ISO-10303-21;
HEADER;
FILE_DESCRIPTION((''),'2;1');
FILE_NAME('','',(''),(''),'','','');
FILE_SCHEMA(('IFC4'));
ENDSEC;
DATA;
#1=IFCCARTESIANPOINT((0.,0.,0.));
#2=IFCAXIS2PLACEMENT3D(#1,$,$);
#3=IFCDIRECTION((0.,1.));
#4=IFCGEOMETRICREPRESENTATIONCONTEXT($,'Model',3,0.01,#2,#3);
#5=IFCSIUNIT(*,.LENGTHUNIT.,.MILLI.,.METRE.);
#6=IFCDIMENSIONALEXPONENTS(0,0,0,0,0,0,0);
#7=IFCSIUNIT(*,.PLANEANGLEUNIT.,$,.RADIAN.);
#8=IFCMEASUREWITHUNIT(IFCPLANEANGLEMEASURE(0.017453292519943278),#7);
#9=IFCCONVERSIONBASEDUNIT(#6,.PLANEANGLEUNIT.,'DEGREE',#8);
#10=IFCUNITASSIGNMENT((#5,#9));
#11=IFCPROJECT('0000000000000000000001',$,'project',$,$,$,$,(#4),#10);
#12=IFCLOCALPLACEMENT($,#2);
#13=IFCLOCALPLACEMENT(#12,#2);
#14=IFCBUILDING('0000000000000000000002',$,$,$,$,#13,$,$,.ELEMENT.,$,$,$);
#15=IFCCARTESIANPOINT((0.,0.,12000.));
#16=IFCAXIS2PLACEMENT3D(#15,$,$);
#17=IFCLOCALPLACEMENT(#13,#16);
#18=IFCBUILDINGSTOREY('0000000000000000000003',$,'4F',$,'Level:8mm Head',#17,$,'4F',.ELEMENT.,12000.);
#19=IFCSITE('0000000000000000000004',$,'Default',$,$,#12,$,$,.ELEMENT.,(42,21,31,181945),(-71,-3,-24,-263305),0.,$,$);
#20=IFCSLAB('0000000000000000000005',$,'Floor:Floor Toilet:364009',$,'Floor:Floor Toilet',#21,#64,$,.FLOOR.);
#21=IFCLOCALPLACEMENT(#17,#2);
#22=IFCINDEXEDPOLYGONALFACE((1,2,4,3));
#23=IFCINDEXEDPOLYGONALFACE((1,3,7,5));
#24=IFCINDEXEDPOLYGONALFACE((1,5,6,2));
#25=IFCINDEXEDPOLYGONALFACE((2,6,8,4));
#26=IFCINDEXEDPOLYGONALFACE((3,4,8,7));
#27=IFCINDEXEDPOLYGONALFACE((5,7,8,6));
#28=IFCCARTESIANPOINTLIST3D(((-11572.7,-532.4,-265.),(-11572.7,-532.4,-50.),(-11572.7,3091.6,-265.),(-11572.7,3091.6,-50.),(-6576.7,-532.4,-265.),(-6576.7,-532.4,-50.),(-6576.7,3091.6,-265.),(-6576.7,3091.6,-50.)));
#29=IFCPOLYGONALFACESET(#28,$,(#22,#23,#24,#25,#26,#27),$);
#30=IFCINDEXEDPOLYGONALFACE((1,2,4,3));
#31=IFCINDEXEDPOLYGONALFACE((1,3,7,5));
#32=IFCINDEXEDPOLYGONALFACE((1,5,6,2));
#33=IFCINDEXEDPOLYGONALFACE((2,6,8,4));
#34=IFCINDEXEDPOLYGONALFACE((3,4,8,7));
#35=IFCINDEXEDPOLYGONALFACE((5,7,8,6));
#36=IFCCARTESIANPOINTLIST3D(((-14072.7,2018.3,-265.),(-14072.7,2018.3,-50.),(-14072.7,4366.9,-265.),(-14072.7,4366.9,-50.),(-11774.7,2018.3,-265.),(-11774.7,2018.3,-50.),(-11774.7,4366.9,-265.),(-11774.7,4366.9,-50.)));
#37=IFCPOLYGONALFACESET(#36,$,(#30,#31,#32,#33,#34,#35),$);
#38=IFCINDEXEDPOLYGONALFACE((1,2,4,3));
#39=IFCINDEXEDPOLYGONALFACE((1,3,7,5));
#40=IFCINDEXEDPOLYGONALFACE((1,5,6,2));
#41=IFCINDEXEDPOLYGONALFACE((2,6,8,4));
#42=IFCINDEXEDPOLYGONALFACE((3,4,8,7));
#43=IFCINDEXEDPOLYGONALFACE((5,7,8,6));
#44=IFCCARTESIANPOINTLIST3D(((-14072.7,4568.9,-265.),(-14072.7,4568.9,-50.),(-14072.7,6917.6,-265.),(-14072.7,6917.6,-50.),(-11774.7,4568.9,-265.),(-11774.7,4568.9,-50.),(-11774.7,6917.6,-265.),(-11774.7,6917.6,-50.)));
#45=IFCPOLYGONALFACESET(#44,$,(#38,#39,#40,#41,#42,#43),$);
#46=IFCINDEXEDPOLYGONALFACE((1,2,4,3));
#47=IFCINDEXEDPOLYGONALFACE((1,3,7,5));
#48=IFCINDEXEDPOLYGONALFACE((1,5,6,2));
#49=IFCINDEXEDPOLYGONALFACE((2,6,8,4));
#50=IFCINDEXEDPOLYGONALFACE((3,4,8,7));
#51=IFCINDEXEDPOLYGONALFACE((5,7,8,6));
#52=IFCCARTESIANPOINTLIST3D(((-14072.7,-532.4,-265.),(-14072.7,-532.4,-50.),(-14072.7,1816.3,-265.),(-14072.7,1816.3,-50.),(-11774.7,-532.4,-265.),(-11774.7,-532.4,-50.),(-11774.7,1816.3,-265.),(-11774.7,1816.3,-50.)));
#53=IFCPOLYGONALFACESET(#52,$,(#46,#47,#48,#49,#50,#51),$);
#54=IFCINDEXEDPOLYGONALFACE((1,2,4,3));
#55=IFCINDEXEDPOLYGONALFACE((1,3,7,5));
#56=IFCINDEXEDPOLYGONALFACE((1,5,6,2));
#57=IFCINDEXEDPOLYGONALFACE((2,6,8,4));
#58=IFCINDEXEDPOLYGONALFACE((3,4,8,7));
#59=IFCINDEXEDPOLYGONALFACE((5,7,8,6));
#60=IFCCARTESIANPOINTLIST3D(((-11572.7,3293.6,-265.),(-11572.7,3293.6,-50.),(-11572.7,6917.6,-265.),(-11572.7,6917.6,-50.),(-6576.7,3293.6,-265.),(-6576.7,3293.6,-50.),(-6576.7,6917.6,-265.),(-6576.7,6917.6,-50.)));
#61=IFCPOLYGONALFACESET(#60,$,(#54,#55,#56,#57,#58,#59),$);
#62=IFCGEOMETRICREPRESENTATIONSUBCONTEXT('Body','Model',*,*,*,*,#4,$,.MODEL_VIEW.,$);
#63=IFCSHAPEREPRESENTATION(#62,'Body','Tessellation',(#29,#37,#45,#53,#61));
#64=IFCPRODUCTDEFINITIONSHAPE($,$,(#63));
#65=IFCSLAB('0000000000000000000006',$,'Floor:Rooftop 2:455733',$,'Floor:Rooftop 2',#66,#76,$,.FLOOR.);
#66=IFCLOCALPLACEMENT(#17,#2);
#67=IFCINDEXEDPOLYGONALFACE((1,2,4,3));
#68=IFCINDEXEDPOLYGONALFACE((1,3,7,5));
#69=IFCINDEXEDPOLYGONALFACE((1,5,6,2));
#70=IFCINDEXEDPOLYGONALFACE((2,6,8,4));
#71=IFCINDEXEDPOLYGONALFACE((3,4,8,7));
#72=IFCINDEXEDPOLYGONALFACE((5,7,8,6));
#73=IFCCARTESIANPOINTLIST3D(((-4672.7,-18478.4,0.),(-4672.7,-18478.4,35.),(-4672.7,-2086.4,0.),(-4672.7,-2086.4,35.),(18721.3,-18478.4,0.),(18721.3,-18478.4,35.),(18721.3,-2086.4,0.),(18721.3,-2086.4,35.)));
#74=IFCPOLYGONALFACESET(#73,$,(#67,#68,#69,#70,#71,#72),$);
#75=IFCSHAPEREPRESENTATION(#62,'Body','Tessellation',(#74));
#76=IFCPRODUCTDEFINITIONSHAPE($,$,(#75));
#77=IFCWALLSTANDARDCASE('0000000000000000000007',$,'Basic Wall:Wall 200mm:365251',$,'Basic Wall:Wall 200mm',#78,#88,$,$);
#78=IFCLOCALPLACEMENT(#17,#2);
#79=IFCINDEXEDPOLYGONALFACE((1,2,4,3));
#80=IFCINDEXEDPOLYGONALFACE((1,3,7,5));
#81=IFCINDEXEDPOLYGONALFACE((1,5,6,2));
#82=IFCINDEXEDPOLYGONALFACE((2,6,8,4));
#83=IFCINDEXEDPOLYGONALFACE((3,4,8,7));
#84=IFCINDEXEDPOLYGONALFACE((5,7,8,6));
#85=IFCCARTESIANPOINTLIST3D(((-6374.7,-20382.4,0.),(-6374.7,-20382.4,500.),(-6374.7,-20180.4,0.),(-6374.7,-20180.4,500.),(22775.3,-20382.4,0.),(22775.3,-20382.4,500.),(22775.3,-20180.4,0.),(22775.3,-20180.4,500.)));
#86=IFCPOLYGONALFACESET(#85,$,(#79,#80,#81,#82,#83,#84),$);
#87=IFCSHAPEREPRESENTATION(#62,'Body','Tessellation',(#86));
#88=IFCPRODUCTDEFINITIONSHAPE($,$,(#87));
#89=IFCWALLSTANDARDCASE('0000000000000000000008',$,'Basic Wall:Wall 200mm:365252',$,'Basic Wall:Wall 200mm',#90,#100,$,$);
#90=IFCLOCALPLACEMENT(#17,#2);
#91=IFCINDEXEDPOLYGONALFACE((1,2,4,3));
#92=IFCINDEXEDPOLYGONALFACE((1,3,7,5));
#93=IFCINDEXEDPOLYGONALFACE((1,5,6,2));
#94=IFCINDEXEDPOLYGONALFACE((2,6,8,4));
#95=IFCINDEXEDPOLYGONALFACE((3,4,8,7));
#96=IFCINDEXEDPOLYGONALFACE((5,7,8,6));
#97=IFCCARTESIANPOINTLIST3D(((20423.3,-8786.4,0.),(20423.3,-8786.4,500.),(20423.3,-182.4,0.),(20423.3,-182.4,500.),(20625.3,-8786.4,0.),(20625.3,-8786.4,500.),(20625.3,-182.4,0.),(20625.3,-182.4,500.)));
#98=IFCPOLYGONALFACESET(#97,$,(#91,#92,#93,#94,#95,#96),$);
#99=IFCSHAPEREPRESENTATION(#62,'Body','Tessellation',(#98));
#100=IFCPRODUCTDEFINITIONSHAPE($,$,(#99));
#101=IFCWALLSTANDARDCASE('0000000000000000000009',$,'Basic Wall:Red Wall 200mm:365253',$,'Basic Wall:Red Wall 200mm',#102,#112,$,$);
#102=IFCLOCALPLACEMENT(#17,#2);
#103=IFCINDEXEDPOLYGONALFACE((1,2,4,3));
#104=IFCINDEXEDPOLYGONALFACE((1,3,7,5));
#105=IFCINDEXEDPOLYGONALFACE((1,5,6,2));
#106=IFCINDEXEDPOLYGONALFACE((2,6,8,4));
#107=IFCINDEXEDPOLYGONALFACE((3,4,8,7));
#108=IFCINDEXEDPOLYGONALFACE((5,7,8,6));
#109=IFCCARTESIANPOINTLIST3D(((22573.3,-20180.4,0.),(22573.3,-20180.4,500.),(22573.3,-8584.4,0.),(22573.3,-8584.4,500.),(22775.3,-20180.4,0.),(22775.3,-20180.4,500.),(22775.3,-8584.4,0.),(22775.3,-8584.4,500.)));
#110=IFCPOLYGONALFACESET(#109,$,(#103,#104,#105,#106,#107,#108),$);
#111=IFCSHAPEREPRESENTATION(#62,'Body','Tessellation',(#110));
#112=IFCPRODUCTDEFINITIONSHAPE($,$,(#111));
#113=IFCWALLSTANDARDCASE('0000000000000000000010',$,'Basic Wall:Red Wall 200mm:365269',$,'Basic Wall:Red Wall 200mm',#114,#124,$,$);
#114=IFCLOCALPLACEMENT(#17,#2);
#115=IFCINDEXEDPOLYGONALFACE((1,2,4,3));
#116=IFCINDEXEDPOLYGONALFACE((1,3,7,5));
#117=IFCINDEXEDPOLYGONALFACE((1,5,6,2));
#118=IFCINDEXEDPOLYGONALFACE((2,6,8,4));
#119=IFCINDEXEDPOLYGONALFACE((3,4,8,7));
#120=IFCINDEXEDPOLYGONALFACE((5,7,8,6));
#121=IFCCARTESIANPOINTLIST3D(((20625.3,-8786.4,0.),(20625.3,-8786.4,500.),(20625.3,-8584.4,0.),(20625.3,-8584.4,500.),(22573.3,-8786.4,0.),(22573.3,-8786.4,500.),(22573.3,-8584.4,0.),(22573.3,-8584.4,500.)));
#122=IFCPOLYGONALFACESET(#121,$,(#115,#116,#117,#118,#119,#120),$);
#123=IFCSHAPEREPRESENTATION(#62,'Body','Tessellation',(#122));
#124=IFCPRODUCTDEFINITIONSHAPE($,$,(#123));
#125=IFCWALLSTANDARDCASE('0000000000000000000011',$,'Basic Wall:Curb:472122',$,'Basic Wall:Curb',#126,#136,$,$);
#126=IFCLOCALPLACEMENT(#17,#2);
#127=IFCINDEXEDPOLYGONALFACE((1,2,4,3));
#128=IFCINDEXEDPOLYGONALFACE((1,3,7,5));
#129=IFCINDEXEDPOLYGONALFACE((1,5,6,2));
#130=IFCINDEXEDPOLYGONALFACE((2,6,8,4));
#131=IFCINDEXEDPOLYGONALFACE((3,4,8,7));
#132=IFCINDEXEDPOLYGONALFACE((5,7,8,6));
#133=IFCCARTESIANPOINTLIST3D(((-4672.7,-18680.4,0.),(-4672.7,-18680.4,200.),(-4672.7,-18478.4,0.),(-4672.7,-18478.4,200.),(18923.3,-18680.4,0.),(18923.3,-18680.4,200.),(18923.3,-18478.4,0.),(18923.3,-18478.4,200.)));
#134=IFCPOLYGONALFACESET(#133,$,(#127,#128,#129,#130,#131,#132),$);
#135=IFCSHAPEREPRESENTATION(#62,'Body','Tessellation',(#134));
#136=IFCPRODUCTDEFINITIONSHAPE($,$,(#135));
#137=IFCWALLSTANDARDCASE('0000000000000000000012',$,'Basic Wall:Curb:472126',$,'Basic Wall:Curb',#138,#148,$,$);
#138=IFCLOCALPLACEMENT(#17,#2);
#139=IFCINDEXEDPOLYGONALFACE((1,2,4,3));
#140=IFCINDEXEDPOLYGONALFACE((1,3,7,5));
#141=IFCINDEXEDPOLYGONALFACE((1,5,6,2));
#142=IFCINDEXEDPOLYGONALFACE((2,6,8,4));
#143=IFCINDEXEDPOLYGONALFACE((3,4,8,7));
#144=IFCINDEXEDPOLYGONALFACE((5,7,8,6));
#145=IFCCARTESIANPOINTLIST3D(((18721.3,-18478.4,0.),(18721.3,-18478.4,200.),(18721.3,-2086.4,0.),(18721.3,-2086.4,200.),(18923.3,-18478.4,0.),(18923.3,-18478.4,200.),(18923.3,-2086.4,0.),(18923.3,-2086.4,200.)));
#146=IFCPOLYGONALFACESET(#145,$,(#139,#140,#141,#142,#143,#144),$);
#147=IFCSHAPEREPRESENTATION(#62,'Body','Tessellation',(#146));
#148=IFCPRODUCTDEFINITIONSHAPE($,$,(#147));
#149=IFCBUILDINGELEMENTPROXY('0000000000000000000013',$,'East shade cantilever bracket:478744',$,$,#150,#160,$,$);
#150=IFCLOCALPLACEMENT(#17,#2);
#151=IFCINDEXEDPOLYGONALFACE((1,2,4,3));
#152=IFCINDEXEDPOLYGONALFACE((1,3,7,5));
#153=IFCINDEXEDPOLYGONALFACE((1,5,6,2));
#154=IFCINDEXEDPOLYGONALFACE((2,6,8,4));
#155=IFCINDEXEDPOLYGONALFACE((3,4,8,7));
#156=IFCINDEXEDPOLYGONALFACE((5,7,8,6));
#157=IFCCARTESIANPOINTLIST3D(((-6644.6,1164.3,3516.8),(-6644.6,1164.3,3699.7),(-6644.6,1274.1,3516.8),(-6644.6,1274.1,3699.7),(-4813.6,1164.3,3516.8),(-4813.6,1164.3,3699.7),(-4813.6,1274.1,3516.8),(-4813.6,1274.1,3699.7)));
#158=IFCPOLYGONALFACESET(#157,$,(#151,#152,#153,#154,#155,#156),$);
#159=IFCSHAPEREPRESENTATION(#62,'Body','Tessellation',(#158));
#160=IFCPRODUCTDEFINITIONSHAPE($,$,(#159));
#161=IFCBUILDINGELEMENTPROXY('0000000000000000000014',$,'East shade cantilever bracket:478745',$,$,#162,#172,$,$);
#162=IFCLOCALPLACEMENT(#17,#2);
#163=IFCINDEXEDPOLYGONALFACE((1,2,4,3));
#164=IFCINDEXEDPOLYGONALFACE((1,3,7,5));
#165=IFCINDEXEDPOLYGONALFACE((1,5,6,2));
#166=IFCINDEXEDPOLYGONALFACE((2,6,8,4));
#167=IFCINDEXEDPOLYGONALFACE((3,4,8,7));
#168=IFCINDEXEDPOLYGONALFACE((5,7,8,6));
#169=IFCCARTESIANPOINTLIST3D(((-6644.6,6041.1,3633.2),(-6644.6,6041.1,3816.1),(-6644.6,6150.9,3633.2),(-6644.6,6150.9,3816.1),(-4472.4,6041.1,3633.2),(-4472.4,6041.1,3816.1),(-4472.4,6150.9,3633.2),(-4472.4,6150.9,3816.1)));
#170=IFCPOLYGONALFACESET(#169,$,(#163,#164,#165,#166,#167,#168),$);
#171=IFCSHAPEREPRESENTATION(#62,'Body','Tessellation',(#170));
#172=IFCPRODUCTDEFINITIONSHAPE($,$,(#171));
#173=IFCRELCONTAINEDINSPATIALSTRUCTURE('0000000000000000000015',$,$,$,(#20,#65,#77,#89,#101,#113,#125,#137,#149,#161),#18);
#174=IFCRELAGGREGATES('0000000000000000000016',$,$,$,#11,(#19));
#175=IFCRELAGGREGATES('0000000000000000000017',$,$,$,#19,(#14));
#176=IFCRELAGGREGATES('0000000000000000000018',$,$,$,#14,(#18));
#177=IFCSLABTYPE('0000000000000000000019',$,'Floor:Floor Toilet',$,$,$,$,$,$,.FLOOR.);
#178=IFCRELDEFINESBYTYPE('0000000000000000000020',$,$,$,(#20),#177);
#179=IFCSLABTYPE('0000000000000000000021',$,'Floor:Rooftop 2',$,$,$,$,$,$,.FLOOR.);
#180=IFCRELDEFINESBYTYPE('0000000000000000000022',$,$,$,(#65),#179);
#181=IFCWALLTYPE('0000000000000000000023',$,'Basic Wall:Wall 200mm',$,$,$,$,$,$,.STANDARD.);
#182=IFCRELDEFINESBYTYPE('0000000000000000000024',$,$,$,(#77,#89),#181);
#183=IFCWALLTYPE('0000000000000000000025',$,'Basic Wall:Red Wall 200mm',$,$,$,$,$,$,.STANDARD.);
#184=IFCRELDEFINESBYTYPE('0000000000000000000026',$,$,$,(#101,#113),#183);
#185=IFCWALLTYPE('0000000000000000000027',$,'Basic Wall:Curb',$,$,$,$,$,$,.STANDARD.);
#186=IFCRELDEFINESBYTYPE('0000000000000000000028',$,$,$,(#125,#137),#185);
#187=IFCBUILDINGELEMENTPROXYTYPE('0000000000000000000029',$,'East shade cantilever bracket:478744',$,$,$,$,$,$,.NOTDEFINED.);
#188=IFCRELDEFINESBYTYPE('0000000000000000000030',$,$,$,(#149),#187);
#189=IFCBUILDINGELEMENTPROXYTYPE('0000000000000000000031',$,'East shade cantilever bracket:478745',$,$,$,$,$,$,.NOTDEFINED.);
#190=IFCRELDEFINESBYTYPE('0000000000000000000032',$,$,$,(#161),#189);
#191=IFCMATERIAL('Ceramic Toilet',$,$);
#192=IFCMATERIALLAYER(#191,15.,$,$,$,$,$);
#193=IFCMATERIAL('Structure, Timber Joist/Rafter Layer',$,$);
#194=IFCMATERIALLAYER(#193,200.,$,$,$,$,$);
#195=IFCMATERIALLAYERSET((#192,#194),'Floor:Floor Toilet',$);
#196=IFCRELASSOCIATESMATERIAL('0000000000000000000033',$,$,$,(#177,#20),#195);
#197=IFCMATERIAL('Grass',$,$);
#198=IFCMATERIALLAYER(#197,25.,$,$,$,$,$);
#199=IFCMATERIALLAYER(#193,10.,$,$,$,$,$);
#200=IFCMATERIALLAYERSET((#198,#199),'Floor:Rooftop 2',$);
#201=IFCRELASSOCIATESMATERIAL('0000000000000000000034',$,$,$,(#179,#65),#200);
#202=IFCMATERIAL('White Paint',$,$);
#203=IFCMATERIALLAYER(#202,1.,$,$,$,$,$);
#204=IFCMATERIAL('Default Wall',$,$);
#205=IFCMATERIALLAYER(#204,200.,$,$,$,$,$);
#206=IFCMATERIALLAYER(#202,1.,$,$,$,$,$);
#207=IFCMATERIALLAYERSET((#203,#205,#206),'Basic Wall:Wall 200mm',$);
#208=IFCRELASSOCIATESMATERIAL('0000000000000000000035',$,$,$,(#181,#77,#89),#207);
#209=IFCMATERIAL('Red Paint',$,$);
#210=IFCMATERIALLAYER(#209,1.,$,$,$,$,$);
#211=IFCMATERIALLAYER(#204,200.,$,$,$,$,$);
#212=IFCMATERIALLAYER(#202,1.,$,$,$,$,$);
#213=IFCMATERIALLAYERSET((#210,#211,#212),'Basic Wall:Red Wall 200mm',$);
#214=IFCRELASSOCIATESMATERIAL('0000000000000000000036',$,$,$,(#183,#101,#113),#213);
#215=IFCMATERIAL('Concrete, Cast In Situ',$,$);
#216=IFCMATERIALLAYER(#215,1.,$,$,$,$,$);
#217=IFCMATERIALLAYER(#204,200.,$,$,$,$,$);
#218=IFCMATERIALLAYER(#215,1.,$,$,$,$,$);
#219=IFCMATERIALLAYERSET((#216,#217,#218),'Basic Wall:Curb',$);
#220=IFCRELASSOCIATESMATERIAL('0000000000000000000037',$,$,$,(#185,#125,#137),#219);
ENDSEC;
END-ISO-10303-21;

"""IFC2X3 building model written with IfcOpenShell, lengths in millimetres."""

from ifc_helpers import new_model, entity, si_unit, converted_unit, direction, frame, frame_2d, origin, origin_2d_with_axis, place, context, subcontext, project, spatial, rectangle, extrude, material, layer, layer_set, layer_usage, type_object, element, save


model = new_model("IFC2X3")

# Units and contexts
model_context = context("Model", 3, precision=0.01, world=origin(), true_north=direction((0.0, 1.0)))
body_context = subcontext(model_context, "Body", "Model", "MODEL_VIEW")
ifc_project = project(units=[si_unit("LENGTHUNIT", "METRE", prefix="MILLI"), converted_unit("PLANEANGLEUNIT", "DEGREE", entity("IfcPlaneAngleMeasure", 0.017453292519943278), si_unit("PLANEANGLEUNIT", "RADIAN"), dimensions=[0, 0, 0, 0, 0, 0, 0])], contexts=[model_context])

# Site, building, storey
site_placement = place(None, origin())
site = spatial("IfcSite", under=ifc_project, at=site_placement, Name="Default", CompositionType="ELEMENT", RefLatitude=(42, 21, 31, 181945), RefLongitude=(-71, -3, -24, -263305), RefElevation=0.0)
building_placement = place(site_placement, origin())
building = spatial("IfcBuilding", under=site, at=building_placement, CompositionType="ELEMENT")
storey_placement = place(building_placement, frame((0.0, 0.0, 12000.0)))
storey = spatial("IfcBuildingStorey", under=building, at=storey_placement, Name="4F", ObjectType="Level:8mm Head", LongName="4F", CompositionType="ELEMENT", Elevation=12000.0)

# Slab
ifc_material_1 = material(Name="Ceramic Toilet")
ifc_layer_1 = layer(ifc_material_1, 15.0)
ifc_material_2 = material(Name="Structure, Timber Joist/Rafter Layer")
ifc_layer_2 = layer(ifc_material_2, 200.0)
ifc_layer_set_1 = layer_set([ifc_layer_1, ifc_layer_2], Name="Floor:Floor Toilet")
ifc_layer_usage_1 = layer_usage(ifc_layer_set_1, "AXIS3", "POSITIVE", 0.0)
slab_type_1 = type_object("IfcSlabType", Name="Floor:Floor Toilet", PredefinedType="FLOOR", material=ifc_layer_set_1)
slab_1_placement = place(storey_placement, origin())
element("IfcSlab", 1, at=slab_1_placement, inside=storey, type_object=slab_type_1, material=ifc_layer_usage_1, Name="Floor:Floor Toilet:364009", ObjectType="Floor:Floor Toilet", PredefinedType="FLOOR", context=body_context, shape_type="SweptSolid", body=[
    extrude(rectangle(XDim=3624.0, YDim=4996.0, at=frame_2d((705.4, 999.4), x_axis=(1.0, 0.0))), frame((-8075.3, 574.2, -265.0), z_axis=(0.0, 0.0, 1.0), x_axis=(0.0, 1.0, 0.0)), (0.0, 0.0, 1.0), 215.0),
    extrude(rectangle(XDim=2348.7, YDim=2298.0, at=frame_2d((0.0, 0.0), x_axis=(1.0, 0.0))), frame((-12923.7, 3192.6, -265.0), z_axis=(0.0, 0.0, 1.0), x_axis=(0.0, 1.0, 0.0)), (0.0, 0.0, 1.0), 215.0),
    extrude(rectangle(XDim=2348.7, YDim=2298.0, at=frame_2d((0.0, 0.0), x_axis=(1.0, 0.0))), frame((-12923.7, 5743.3, -265.0), z_axis=(0.0, 0.0, 1.0), x_axis=(0.0, 1.0, 0.0)), (0.0, 0.0, 1.0), 215.0),
    extrude(rectangle(XDim=2298.0, YDim=2348.7, at=frame_2d((-300.0, -333.1), x_axis=(1.0, 0.0))), frame((-13223.7, 308.8, -265.0), z_axis=(0.0, 0.0, 1.0), x_axis=(-1.0, 0.0, 0.0)), (0.0, 0.0, 1.0), 215.0),
    extrude(rectangle(XDim=3624.0, YDim=4996.0, at=frame_2d((0.0, 0.0), x_axis=(1.0, 0.0))), frame((-9074.7, 5105.6, -265.0), z_axis=(0.0, 0.0, 1.0), x_axis=(0.0, 1.0, 0.0)), (0.0, 0.0, 1.0), 215.0),
])
ifc_material_3 = material(Name="White Paint")

# Slab
ifc_material_4 = material(Name="Grass")
ifc_layer_3 = layer(ifc_material_4, 25.0)
ifc_layer_4 = layer(ifc_material_2, 10.0)
ifc_layer_set_2 = layer_set([ifc_layer_3, ifc_layer_4], Name="Floor:Rooftop 2")
ifc_layer_usage_2 = layer_usage(ifc_layer_set_2, "AXIS3", "POSITIVE", 0.0)
slab_type_2 = type_object("IfcSlabType", Name="Floor:Rooftop 2", PredefinedType="FLOOR", material=ifc_layer_set_2)
slab_2_placement = place(storey_placement, origin())
element("IfcSlab", 2, at=slab_2_placement, inside=storey, type_object=slab_type_2, material=ifc_layer_usage_2, Name="Floor:Rooftop 2:455733", ObjectType="Floor:Rooftop 2", PredefinedType="FLOOR", context=body_context, shape_type="SweptSolid", body=[
    extrude(rectangle(XDim=16392.0, YDim=23394.0, at=frame_2d((0.0, 0.0), x_axis=(1.0, 0.0))), frame((7024.3, -10282.4, 35.0), z_axis=(0.0, 0.0, -1.0), x_axis=(0.0, 1.0, 0.0)), (0.0, 0.0, 1.0), 35.0),
])

# Walls
ifc_layer_5 = layer(ifc_material_3, 1.0)
ifc_material_5 = material(Name="Default Wall")
ifc_layer_6 = layer(ifc_material_5, 200.0)
ifc_layer_7 = layer(ifc_material_3, 1.0)
ifc_layer_set_3 = layer_set([ifc_layer_5, ifc_layer_6, ifc_layer_7], Name="Basic Wall:Wall 200mm")
wall_type_1 = type_object("IfcWallType", Name="Basic Wall:Wall 200mm", PredefinedType="STANDARD", material=ifc_layer_set_3)
ifc_layer_usage_3 = layer_usage(ifc_layer_set_3, "AXIS2", "NEGATIVE", 101.0)
wall_1_placement = place(storey_placement, frame((22775.3, -20281.4, 0.0), z_axis=(0.0, 0.0, 1.0), x_axis=(-1.0, 0.0, 0.0)))
element("IfcWallStandardCase", 3, at=wall_1_placement, inside=storey, type_object=wall_type_1, material=ifc_layer_usage_3, Name="Basic Wall:Wall 200mm:365251", ObjectType="Basic Wall:Wall 200mm", context=body_context, shape_type="SweptSolid", body=[
    extrude(rectangle(XDim=29150.0, YDim=202.0, at=frame_2d((14575.0, 0.0), x_axis=(-1.0, 0.0))), origin(), (0.0, 0.0, 1.0), 500.0),
])
ifc_layer_usage_4 = layer_usage(ifc_layer_set_3, "AXIS2", "POSITIVE", -101.0)
wall_2_placement = place(storey_placement, frame((20524.3, -8786.4, 0.0), z_axis=(0.0, 0.0, 1.0), x_axis=(0.0, 1.0, 0.0)))
element("IfcWallStandardCase", 4, at=wall_2_placement, inside=storey, type_object=wall_type_1, material=ifc_layer_usage_4, Name="Basic Wall:Wall 200mm:365252", ObjectType="Basic Wall:Wall 200mm", context=body_context, shape_type="SweptSolid", body=[
    extrude(rectangle(XDim=8604.0, YDim=202.0, at=frame_2d((4302.0, 0.0), x_axis=(-1.0, 0.0))), origin(), (0.0, 0.0, 1.0), 500.0),
])
ifc_material_6 = material(Name="Red Paint")
ifc_layer_8 = layer(ifc_material_6, 1.0)
ifc_layer_9 = layer(ifc_material_5, 200.0)
ifc_layer_10 = layer(ifc_material_3, 1.0)
ifc_layer_set_4 = layer_set([ifc_layer_8, ifc_layer_9, ifc_layer_10], Name="Basic Wall:Red Wall 200mm")
ifc_layer_usage_5 = layer_usage(ifc_layer_set_4, "AXIS2", "POSITIVE", -101.0)
wall_type_2 = type_object("IfcWallType", Name="Basic Wall:Red Wall 200mm", PredefinedType="STANDARD", material=ifc_layer_set_4)
wall_3_placement = place(storey_placement, frame((22674.3, -20180.4, 0.0), z_axis=(0.0, 0.0, 1.0), x_axis=(0.0, 1.0, 0.0)))
element("IfcWallStandardCase", 5, at=wall_3_placement, inside=storey, type_object=wall_type_2, material=ifc_layer_usage_5, Name="Basic Wall:Red Wall 200mm:365253", ObjectType="Basic Wall:Red Wall 200mm", context=body_context, shape_type="SweptSolid", body=[
    extrude(rectangle(XDim=11596.0, YDim=202.0, at=frame_2d((5798.0, 0.0), x_axis=(-1.0, 0.0))), origin(), (0.0, 0.0, 1.0), 500.0),
])
ifc_layer_usage_6 = layer_usage(ifc_layer_set_4, "AXIS2", "POSITIVE", -101.0)
wall_4_placement = place(storey_placement, frame((22573.3, -8685.4, 0.0), z_axis=(0.0, 0.0, 1.0), x_axis=(-1.0, 0.0, 0.0)))
element("IfcWallStandardCase", 6, at=wall_4_placement, inside=storey, type_object=wall_type_2, material=ifc_layer_usage_6, Name="Basic Wall:Red Wall 200mm:365269", ObjectType="Basic Wall:Red Wall 200mm", context=body_context, shape_type="SweptSolid", body=[
    extrude(rectangle(XDim=1948.0, YDim=202.0, at=frame_2d((974.0, 0.0), x_axis=(-1.0, 0.0))), origin(), (0.0, 0.0, 1.0), 500.0),
])
ifc_material_7 = material(Name="Concrete, Cast In Situ")
ifc_layer_11 = layer(ifc_material_7, 1.0)
ifc_layer_12 = layer(ifc_material_5, 200.0)
ifc_layer_13 = layer(ifc_material_7, 1.0)
ifc_layer_set_5 = layer_set([ifc_layer_11, ifc_layer_12, ifc_layer_13], Name="Basic Wall:Curb")
ifc_layer_usage_7 = layer_usage(ifc_layer_set_5, "AXIS2", "NEGATIVE", 101.0)
wall_type_3 = type_object("IfcWallType", Name="Basic Wall:Curb", PredefinedType="STANDARD", material=ifc_layer_set_5)
wall_5_placement = place(storey_placement, frame((18923.3, -18579.4, 0.0), z_axis=(0.0, 0.0, 1.0), x_axis=(-1.0, 0.0, 0.0)))
element("IfcWallStandardCase", 7, at=wall_5_placement, inside=storey, type_object=wall_type_3, material=ifc_layer_usage_7, Name="Basic Wall:Curb:472122", ObjectType="Basic Wall:Curb", context=body_context, shape_type="SweptSolid", body=[
    extrude(rectangle(XDim=23596.0, YDim=202.0, at=frame_2d((11798.0, 0.0), x_axis=(-1.0, 0.0))), origin(), (0.0, 0.0, 1.0), 200.0),
])
ifc_layer_usage_8 = layer_usage(ifc_layer_set_5, "AXIS2", "NEGATIVE", 101.0)
wall_6_placement = place(storey_placement, frame((18822.3, -2086.4, 0.0), z_axis=(0.0, 0.0, 1.0), x_axis=(0.0, -1.0, 0.0)))
element("IfcWallStandardCase", 8, at=wall_6_placement, inside=storey, type_object=wall_type_3, material=ifc_layer_usage_8, Name="Basic Wall:Curb:472126", ObjectType="Basic Wall:Curb", context=body_context, shape_type="SweptSolid", body=[
    extrude(rectangle(XDim=16392.0, YDim=202.0, at=frame_2d((8196.0, 0.0), x_axis=(-1.0, 0.0))), origin(), (0.0, 0.0, 1.0), 200.0),
])

# Building element proxies
building_element_proxy_type_1 = type_object("IfcBuildingElementProxyType", Name="East shade cantilever bracket:478744", PredefinedType="NOTDEFINED")
proxy_1_placement = place(storey_placement, origin())
element("IfcBuildingElementProxy", 9, at=proxy_1_placement, inside=storey, type_object=building_element_proxy_type_1, Name="East shade cantilever bracket:478744", context=body_context, shape_type="SweptSolid", body=[
    extrude(rectangle(XDim=1831.0, YDim=109.7, at=frame_2d((0.0, 0.0), x_axis=(1.0, 0.0))), frame((-5729.1, 1219.2, 3516.8)), (0.0, 0.0, 1.0), 182.9),
])
building_element_proxy_type_2 = type_object("IfcBuildingElementProxyType", Name="East shade cantilever bracket:478745", PredefinedType="NOTDEFINED")
proxy_2_placement = place(storey_placement, origin())
element("IfcBuildingElementProxy", 10, at=proxy_2_placement, inside=storey, type_object=building_element_proxy_type_2, Name="East shade cantilever bracket:478745", context=body_context, shape_type="SweptSolid", body=[
    extrude(rectangle(XDim=2172.2, YDim=109.7, at=origin_2d_with_axis()), frame((-5558.5, 6096.0, 3633.2)), (0.0, 0.0, 1.0), 182.9),
])

save(model, "model.ifc")
